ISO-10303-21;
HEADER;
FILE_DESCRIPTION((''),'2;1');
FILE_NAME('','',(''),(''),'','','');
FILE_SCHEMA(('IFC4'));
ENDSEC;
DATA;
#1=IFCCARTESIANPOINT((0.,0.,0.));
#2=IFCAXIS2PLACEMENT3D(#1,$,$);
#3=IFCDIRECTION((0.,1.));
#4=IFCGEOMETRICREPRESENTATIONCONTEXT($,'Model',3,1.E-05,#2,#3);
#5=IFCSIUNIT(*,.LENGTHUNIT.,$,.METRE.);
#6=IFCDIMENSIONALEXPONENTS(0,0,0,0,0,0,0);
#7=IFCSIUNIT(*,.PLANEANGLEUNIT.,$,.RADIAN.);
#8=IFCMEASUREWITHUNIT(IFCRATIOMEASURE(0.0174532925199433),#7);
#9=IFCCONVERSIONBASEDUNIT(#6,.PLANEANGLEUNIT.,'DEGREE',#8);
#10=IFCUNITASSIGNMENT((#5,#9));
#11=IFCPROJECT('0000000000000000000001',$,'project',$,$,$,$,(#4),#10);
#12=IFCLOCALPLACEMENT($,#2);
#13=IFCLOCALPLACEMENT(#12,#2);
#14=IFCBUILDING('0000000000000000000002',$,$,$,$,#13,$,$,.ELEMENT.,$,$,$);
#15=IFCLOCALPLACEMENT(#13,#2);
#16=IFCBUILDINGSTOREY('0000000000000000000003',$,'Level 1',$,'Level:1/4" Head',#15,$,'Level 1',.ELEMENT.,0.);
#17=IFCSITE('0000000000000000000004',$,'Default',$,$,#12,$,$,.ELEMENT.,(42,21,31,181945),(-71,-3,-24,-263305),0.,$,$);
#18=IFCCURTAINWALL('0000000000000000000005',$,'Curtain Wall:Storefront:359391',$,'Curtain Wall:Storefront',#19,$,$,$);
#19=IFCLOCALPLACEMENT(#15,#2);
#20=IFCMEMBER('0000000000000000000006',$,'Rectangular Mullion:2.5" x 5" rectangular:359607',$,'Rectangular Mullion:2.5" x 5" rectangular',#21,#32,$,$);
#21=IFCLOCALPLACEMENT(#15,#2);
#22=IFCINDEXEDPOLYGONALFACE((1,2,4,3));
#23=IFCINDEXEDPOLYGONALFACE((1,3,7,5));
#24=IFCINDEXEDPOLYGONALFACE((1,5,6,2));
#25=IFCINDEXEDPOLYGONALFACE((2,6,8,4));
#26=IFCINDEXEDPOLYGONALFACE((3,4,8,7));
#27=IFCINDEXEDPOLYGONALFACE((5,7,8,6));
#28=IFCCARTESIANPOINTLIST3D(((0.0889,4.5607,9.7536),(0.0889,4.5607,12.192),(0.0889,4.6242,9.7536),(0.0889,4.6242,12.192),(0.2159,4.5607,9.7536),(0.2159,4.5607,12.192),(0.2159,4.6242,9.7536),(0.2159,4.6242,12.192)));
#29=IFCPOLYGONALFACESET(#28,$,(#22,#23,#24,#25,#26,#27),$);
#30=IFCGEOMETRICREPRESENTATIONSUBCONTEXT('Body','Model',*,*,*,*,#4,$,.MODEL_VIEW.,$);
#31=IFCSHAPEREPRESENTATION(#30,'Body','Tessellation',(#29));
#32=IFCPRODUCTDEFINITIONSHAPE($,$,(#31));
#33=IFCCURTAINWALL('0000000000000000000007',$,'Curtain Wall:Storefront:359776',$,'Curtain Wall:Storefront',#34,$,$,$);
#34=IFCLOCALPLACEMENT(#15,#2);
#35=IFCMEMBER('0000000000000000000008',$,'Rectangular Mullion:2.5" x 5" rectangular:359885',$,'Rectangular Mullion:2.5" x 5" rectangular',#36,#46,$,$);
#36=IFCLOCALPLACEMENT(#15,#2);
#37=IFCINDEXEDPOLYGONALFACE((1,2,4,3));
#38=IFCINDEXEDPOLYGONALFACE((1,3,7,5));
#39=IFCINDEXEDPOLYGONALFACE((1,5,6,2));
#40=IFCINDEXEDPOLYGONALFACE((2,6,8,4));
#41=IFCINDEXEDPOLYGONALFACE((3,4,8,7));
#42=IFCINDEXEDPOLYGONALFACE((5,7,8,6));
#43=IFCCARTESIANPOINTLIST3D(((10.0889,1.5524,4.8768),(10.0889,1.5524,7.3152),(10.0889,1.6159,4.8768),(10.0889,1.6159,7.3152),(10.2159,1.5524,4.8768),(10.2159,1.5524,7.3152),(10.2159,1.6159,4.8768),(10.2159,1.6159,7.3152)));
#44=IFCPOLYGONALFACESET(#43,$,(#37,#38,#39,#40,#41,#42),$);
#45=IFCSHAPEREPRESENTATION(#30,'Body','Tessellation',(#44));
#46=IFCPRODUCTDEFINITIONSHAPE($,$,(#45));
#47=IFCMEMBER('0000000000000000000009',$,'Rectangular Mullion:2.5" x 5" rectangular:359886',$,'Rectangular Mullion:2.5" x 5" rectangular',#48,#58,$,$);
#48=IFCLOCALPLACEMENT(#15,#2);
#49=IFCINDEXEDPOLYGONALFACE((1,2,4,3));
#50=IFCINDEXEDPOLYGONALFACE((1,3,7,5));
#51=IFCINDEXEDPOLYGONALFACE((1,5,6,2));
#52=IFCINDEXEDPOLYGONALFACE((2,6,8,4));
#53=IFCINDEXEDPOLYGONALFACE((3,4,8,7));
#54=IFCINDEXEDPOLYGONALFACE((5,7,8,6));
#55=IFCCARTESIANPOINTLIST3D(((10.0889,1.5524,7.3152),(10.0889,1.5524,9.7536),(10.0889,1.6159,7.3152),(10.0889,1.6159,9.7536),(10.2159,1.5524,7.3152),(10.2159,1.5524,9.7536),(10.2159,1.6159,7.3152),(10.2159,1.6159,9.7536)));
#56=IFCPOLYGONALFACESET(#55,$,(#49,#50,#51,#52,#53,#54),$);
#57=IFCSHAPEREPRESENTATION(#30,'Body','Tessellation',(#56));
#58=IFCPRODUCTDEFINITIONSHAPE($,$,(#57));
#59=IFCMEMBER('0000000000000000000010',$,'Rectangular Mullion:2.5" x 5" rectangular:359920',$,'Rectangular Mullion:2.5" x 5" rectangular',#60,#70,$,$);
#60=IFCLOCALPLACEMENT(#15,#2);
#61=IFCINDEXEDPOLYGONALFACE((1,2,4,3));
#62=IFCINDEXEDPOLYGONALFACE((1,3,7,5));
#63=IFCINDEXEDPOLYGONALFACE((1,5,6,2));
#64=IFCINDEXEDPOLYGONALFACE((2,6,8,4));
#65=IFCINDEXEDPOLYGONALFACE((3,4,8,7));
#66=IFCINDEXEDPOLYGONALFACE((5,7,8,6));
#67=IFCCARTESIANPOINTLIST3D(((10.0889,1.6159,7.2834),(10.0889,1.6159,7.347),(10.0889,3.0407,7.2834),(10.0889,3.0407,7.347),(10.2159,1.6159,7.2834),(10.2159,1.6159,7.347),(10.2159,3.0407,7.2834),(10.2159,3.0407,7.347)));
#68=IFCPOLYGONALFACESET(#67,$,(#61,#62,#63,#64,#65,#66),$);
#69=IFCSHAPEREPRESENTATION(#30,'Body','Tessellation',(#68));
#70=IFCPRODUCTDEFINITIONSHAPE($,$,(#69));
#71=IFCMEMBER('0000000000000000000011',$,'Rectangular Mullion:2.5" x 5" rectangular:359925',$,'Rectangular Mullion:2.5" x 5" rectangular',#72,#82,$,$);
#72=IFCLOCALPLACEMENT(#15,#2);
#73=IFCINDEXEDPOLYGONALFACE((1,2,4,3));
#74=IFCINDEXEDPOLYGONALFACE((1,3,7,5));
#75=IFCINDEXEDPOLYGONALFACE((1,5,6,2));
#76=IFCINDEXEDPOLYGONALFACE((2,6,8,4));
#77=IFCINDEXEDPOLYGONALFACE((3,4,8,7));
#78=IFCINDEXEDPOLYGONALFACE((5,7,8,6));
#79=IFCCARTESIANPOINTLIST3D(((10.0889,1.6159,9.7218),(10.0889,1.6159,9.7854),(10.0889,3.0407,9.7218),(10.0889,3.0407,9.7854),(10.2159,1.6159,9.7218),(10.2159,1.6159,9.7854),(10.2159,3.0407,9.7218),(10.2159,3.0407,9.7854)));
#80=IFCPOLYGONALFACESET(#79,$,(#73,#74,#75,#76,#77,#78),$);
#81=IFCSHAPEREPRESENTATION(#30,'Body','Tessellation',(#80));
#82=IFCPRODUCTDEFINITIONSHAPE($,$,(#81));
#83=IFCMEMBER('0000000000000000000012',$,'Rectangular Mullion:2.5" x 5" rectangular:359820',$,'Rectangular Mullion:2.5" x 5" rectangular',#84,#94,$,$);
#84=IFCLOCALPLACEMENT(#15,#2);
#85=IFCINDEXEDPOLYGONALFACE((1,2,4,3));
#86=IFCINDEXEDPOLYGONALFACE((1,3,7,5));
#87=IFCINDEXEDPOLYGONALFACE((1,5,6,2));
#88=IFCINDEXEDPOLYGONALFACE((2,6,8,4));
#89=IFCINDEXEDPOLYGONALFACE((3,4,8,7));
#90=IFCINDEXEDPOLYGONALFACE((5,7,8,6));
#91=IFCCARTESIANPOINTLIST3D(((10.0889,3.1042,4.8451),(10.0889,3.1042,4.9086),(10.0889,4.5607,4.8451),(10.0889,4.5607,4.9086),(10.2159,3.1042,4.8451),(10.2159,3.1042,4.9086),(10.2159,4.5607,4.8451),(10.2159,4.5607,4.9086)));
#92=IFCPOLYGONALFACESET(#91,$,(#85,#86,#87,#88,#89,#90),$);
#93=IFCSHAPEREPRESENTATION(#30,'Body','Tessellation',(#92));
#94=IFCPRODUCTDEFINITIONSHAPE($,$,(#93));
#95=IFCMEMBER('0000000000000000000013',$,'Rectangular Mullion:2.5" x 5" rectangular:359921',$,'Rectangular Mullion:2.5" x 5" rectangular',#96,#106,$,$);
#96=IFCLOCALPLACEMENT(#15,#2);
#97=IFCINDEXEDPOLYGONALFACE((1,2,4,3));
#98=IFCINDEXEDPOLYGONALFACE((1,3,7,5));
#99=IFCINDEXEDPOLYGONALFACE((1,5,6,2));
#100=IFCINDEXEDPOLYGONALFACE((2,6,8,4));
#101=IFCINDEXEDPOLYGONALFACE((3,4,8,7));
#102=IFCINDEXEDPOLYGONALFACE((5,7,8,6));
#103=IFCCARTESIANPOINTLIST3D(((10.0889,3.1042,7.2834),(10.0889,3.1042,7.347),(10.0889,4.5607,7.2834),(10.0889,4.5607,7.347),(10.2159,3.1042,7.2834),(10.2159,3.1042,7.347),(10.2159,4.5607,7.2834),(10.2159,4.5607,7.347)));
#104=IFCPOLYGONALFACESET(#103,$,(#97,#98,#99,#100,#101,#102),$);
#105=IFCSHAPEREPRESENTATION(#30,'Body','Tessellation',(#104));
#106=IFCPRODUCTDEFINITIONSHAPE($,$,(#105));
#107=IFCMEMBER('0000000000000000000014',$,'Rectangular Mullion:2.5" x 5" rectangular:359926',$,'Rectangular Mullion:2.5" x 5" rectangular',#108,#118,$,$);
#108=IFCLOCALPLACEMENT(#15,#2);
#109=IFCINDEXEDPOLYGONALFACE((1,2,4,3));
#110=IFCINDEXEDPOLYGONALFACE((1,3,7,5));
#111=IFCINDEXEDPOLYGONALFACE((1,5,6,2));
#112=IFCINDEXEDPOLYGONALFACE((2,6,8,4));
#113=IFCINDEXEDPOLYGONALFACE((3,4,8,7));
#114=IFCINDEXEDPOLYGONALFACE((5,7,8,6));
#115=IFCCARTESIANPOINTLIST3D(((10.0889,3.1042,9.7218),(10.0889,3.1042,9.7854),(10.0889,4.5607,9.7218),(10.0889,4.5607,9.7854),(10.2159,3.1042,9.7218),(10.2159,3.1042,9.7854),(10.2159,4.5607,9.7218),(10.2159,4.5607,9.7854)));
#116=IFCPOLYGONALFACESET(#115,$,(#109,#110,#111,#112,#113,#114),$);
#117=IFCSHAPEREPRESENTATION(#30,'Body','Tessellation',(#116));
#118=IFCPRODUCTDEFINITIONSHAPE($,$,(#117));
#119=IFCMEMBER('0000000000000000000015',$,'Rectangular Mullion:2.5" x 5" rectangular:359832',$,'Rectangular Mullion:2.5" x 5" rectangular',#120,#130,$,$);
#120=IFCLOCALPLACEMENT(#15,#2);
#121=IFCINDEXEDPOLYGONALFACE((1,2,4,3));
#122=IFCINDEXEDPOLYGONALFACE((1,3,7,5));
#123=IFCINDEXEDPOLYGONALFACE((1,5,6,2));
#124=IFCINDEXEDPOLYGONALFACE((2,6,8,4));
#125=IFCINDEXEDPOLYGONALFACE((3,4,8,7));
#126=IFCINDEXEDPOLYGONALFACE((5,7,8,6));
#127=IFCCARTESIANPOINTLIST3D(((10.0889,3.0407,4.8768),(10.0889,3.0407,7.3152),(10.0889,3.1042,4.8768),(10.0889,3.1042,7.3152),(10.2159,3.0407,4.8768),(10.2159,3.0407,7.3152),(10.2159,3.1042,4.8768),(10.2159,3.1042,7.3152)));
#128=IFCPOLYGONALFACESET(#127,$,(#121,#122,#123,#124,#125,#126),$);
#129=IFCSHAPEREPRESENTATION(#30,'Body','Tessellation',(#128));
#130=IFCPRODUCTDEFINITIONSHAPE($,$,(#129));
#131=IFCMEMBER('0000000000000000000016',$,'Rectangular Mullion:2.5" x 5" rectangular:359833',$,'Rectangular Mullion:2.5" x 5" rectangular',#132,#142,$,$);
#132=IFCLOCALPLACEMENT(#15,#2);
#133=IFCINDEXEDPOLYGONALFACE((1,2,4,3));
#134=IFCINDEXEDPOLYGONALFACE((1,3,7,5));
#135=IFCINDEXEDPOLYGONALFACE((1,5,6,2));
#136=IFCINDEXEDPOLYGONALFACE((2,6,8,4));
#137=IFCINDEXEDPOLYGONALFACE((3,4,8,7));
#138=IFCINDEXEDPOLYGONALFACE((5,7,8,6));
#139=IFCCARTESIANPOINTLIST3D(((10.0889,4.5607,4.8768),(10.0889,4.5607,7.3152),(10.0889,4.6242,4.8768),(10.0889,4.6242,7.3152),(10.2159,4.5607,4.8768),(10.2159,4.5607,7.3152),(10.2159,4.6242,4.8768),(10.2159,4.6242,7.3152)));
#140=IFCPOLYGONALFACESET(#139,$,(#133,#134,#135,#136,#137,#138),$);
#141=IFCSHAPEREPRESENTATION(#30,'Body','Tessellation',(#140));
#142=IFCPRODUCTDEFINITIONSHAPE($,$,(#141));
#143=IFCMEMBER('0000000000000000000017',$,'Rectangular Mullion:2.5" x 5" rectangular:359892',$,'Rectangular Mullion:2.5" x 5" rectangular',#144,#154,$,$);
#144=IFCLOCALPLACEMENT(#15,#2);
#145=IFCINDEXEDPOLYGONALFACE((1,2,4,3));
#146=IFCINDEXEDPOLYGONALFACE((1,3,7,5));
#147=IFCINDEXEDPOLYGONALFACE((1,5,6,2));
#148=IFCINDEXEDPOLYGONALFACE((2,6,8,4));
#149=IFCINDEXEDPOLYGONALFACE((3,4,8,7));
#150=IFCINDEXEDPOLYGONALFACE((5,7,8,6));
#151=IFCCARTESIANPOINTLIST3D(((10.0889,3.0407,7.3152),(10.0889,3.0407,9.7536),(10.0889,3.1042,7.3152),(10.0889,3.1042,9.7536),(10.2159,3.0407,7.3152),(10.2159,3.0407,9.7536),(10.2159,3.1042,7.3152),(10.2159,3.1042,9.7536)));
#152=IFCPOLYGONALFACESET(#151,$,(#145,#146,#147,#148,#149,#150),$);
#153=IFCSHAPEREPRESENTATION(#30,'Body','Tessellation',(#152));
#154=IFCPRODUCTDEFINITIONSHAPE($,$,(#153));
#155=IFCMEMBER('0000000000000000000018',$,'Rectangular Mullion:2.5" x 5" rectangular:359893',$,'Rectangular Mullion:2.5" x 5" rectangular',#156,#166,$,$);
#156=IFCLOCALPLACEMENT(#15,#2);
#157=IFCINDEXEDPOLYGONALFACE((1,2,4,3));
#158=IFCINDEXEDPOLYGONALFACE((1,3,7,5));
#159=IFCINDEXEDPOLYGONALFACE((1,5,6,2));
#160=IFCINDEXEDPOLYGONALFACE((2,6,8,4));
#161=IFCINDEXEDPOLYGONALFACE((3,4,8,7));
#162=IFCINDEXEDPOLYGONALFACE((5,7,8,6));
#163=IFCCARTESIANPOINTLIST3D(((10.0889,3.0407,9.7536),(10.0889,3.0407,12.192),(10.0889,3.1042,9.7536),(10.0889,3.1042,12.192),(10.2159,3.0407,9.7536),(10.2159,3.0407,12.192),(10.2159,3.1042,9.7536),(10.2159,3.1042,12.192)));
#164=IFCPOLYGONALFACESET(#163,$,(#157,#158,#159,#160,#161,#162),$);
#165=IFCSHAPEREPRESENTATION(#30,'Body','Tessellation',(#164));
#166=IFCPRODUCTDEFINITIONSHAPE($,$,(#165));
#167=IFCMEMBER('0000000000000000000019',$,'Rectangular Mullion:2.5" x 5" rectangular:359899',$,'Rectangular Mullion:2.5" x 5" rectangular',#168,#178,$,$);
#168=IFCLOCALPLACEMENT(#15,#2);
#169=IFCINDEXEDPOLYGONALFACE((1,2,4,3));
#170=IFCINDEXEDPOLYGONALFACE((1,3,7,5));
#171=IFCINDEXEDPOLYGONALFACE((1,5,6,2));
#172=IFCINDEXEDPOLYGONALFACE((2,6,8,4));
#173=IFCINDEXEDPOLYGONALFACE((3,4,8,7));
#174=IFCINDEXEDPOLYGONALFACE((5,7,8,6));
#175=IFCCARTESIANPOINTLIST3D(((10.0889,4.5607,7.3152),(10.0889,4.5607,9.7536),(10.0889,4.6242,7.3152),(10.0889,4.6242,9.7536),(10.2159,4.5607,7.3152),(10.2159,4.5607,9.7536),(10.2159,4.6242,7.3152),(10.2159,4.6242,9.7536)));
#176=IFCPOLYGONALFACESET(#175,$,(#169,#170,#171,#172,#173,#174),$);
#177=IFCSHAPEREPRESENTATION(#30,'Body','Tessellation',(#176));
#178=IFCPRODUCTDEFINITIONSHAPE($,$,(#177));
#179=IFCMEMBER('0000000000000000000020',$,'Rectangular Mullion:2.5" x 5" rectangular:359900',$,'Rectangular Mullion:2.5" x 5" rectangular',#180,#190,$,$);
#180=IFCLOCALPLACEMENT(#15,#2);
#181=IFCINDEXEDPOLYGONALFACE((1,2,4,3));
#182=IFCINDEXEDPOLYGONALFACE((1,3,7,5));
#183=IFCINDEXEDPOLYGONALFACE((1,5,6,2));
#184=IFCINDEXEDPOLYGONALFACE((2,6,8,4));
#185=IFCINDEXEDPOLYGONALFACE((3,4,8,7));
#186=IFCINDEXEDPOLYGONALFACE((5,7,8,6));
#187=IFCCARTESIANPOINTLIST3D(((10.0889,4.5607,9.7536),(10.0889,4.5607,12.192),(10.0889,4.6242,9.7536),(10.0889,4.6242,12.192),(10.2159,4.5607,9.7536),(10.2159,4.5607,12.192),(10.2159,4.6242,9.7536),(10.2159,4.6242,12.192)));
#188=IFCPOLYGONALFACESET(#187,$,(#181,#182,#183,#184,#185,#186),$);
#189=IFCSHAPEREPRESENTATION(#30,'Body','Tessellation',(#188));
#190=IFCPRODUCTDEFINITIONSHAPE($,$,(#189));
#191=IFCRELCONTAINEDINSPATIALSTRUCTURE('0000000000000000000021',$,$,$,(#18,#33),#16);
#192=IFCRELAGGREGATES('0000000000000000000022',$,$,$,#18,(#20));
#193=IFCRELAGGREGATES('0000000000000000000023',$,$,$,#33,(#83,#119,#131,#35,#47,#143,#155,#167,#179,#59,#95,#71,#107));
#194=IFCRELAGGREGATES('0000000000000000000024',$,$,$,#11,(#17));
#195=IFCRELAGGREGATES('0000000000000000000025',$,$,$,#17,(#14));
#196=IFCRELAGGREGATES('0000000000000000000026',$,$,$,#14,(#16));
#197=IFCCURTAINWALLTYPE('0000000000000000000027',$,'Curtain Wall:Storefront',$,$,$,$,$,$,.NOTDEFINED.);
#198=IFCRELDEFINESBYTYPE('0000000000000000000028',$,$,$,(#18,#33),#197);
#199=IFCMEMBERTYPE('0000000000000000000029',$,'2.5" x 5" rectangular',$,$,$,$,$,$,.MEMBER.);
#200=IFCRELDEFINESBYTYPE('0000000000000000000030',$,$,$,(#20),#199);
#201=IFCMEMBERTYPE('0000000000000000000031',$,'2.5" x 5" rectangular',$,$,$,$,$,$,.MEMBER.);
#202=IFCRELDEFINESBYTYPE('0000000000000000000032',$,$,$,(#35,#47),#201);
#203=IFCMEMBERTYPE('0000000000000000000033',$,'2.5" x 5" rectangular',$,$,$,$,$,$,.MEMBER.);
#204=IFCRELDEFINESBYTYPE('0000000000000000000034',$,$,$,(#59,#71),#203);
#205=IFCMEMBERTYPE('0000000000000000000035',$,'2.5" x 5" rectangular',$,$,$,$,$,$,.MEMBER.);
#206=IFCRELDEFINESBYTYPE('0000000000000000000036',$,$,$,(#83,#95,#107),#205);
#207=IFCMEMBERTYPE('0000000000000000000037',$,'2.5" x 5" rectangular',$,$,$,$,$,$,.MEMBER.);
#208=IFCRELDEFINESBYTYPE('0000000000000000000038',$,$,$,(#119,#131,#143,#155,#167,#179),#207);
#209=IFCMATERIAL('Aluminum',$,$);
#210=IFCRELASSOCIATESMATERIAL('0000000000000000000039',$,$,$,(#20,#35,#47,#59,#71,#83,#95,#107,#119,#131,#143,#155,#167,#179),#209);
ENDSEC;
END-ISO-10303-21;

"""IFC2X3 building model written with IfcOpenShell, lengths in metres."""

from ifc_helpers import new_model, entity, si_unit, converted_unit, direction, frame, origin, origin_2d_with_axis, place, context, subcontext, project, spatial, rectangle, extrude, source, transform, mapped, material, type_object, type_shapes, element, aggregate, save


model = new_model("IFC2X3")

# Units and contexts
model_context = context("Model", 3, precision=1e-05, world=origin(), true_north=direction((0.0, 1.0)))
body_context = subcontext(model_context, "Body", "Model", "MODEL_VIEW")
ifc_project = project(units=[si_unit("LENGTHUNIT", "METRE"), converted_unit("PLANEANGLEUNIT", "DEGREE", entity("IfcRatioMeasure", 0.0174532925199433), si_unit("PLANEANGLEUNIT", "RADIAN"), dimensions=[0, 0, 0, 0, 0, 0, 0])], contexts=[model_context])

# Site, building, storey
site_placement = place(None, origin())
site = spatial("IfcSite", under=ifc_project, at=site_placement, Name="Default", CompositionType="ELEMENT", RefLatitude=(42, 21, 31, 181945), RefLongitude=(-71, -3, -24, -263305), RefElevation=0.0)
building_placement = place(site_placement, origin())
building = spatial("IfcBuilding", under=site, at=building_placement, CompositionType="ELEMENT")
storey_placement = place(building_placement, origin())
storey = spatial("IfcBuildingStorey", under=building, at=storey_placement, Name="Level 1", ObjectType="Level:1/4\" Head", LongName="Level 1", CompositionType="ELEMENT", Elevation=0.0)

# Curtain wall, member
curtain_wall_type = type_object("IfcCurtainWallType", Name="Curtain Wall:Storefront", PredefinedType="NOTDEFINED")
curtain_wall_1_placement = place(storey_placement, origin())
curtain_wall_1 = element("IfcCurtainWall", 1, at=curtain_wall_1_placement, inside=storey, type_object=curtain_wall_type, Name="Curtain Wall:Storefront:359391", ObjectType="Curtain Wall:Storefront")
ifc_material_1 = material(Name="Aluminum")
member_type_1 = type_object("IfcMemberType", Name="2.5\" x 5\" rectangular", PredefinedType="MEMBER")
shared_shape_1 = source(origin(), body_context, "Body", "SweptSolid", [
    extrude(rectangle(XDim=0.127, YDim=0.0635, at=origin_2d_with_axis()), frame((0.0, 0.0, -2.4384), z_axis=(0.0, 0.0, 1.0), x_axis=(0.0, -1.0, 0.0)), (0.0, 0.0, 1.0), 2.4384),
])
type_shapes(member_type_1, [shared_shape_1])
member_1_placement = place(storey_placement, frame((0.1524, 4.5924, 9.7536), z_axis=(0.0, 0.0, -1.0), x_axis=(0.0, 1.0, 0.0)))
member_1 = element("IfcMember", 2, at=member_1_placement, type_object=member_type_1, material=ifc_material_1, Name="Rectangular Mullion:2.5\" x 5\" rectangular:359607", ObjectType="Rectangular Mullion:2.5\" x 5\" rectangular", context=body_context, shape_type="MappedRepresentation", body=[
    mapped(shared_shape_1, transform((0.0, 0.0, 0.0), scale=1.0)),
])
aggregate(curtain_wall_1, [member_1])

# Curtain wall, members
curtain_wall_2_placement = place(storey_placement, origin())
curtain_wall_2 = element("IfcCurtainWall", 3, at=curtain_wall_2_placement, inside=storey, type_object=curtain_wall_type, Name="Curtain Wall:Storefront:359776", ObjectType="Curtain Wall:Storefront")
member_type_2 = type_object("IfcMemberType", Name="2.5\" x 5\" rectangular", PredefinedType="MEMBER")
shared_shape_2 = source(origin(), body_context, "Body", "SweptSolid", [
    extrude(rectangle(XDim=0.127, YDim=0.0635, at=origin_2d_with_axis()), frame((-0.0318, 0.0, -2.4384), z_axis=(0.0, 0.0, 1.0), x_axis=(0.0, -1.0, 0.0)), (0.0, 0.0, 1.0), 2.4384),
])
type_shapes(member_type_2, [shared_shape_2])
member_2_placement = place(storey_placement, frame((10.1524, 1.5524, 7.3152), z_axis=(0.0, 0.0, 1.0), x_axis=(0.0, -1.0, 0.0)))
member_2 = element("IfcMember", 4, at=member_2_placement, type_object=member_type_2, material=ifc_material_1, Name="Rectangular Mullion:2.5\" x 5\" rectangular:359885", ObjectType="Rectangular Mullion:2.5\" x 5\" rectangular", context=body_context, shape_type="MappedRepresentation", body=[
    mapped(shared_shape_2, transform((0.0, 0.0, 0.0), scale=1.0)),
])
member_3_placement = place(storey_placement, frame((10.1524, 1.5524, 9.7536), z_axis=(0.0, 0.0, 1.0), x_axis=(0.0, -1.0, 0.0)))
member_3 = element("IfcMember", 5, at=member_3_placement, type_object=member_type_2, material=ifc_material_1, Name="Rectangular Mullion:2.5\" x 5\" rectangular:359886", ObjectType="Rectangular Mullion:2.5\" x 5\" rectangular", context=body_context, shape_type="MappedRepresentation", body=[
    mapped(shared_shape_2, transform((0.0, 0.0, 0.0), scale=1.0)),
])
member_type_3 = type_object("IfcMemberType", Name="2.5\" x 5\" rectangular", PredefinedType="MEMBER")
shared_shape_3 = source(origin(), body_context, "Body", "SweptSolid", [
    extrude(rectangle(XDim=0.127, YDim=0.0635, at=origin_2d_with_axis()), frame((0.0, 0.0, -1.4248), z_axis=(0.0, 0.0, 1.0), x_axis=(0.0, -1.0, 0.0)), (0.0, 0.0, 1.0), 1.4248),
])
type_shapes(member_type_3, [shared_shape_3])
member_4_placement = place(storey_placement, frame((10.1524, 3.0407, 7.3152), z_axis=(0.0, 1.0, 0.0), x_axis=(0.0, 0.0, 1.0)))
member_4 = element("IfcMember", 6, at=member_4_placement, type_object=member_type_3, material=ifc_material_1, Name="Rectangular Mullion:2.5\" x 5\" rectangular:359920", ObjectType="Rectangular Mullion:2.5\" x 5\" rectangular", context=body_context, shape_type="MappedRepresentation", body=[
    mapped(shared_shape_3, transform((0.0, 0.0, 0.0), scale=1.0)),
])
member_5_placement = place(storey_placement, frame((10.1524, 3.0407, 9.7536), z_axis=(0.0, 1.0, 0.0), x_axis=(0.0, 0.0, 1.0)))
member_5 = element("IfcMember", 7, at=member_5_placement, type_object=member_type_3, material=ifc_material_1, Name="Rectangular Mullion:2.5\" x 5\" rectangular:359925", ObjectType="Rectangular Mullion:2.5\" x 5\" rectangular", context=body_context, shape_type="MappedRepresentation", body=[
    mapped(shared_shape_3, transform((0.0, 0.0, 0.0), scale=1.0)),
])
member_type_4 = type_object("IfcMemberType", Name="2.5\" x 5\" rectangular", PredefinedType="MEMBER")
shared_shape_4 = source(origin(), body_context, "Body", "SweptSolid", [
    extrude(rectangle(XDim=0.127, YDim=0.0635, at=origin_2d_with_axis()), frame((0.0, 0.0, -1.4565), z_axis=(0.0, 0.0, 1.0), x_axis=(0.0, -1.0, 0.0)), (0.0, 0.0, 1.0), 1.4565),
])
type_shapes(member_type_4, [shared_shape_4])
member_6_placement = place(storey_placement, frame((10.1524, 4.5607, 4.8768), z_axis=(0.0, 1.0, 0.0), x_axis=(0.0, 0.0, 1.0)))
member_6 = element("IfcMember", 8, at=member_6_placement, type_object=member_type_4, material=ifc_material_1, Name="Rectangular Mullion:2.5\" x 5\" rectangular:359820", ObjectType="Rectangular Mullion:2.5\" x 5\" rectangular", context=body_context, shape_type="MappedRepresentation", body=[
    mapped(shared_shape_4, transform((0.0, 0.0, 0.0), scale=1.0)),
])
member_7_placement = place(storey_placement, frame((10.1524, 4.5607, 7.3152), z_axis=(0.0, 1.0, 0.0), x_axis=(0.0, 0.0, 1.0)))
member_7 = element("IfcMember", 9, at=member_7_placement, type_object=member_type_4, material=ifc_material_1, Name="Rectangular Mullion:2.5\" x 5\" rectangular:359921", ObjectType="Rectangular Mullion:2.5\" x 5\" rectangular", context=body_context, shape_type="MappedRepresentation", body=[
    mapped(shared_shape_4, transform((0.0, 0.0, 0.0), scale=1.0)),
])
member_8_placement = place(storey_placement, frame((10.1524, 4.5607, 9.7536), z_axis=(0.0, 1.0, 0.0), x_axis=(0.0, 0.0, 1.0)))
member_8 = element("IfcMember", 10, at=member_8_placement, type_object=member_type_4, material=ifc_material_1, Name="Rectangular Mullion:2.5\" x 5\" rectangular:359926", ObjectType="Rectangular Mullion:2.5\" x 5\" rectangular", context=body_context, shape_type="MappedRepresentation", body=[
    mapped(shared_shape_4, transform((0.0, 0.0, 0.0), scale=1.0)),
])
member_type_5 = type_object("IfcMemberType", Name="2.5\" x 5\" rectangular", PredefinedType="MEMBER")
shared_shape_5 = source(origin(), body_context, "Body", "SweptSolid", [
    extrude(rectangle(XDim=0.127, YDim=0.0635, at=origin_2d_with_axis()), frame((0.0, 0.0, -2.4384), z_axis=(0.0, 0.0, 1.0), x_axis=(0.0, -1.0, 0.0)), (0.0, 0.0, 1.0), 2.4384),
])
type_shapes(member_type_5, [shared_shape_5])
member_9_placement = place(storey_placement, frame((10.1524, 3.0724, 4.8768), z_axis=(0.0, 0.0, -1.0), x_axis=(0.0, 1.0, 0.0)))
member_9 = element("IfcMember", 11, at=member_9_placement, type_object=member_type_5, material=ifc_material_1, Name="Rectangular Mullion:2.5\" x 5\" rectangular:359832", ObjectType="Rectangular Mullion:2.5\" x 5\" rectangular", context=body_context, shape_type="MappedRepresentation", body=[
    mapped(shared_shape_5, transform((0.0, 0.0, 0.0), scale=1.0)),
])
member_10_placement = place(storey_placement, frame((10.1524, 4.5924, 4.8768), z_axis=(0.0, 0.0, -1.0), x_axis=(0.0, 1.0, 0.0)))
member_10 = element("IfcMember", 12, at=member_10_placement, type_object=member_type_5, material=ifc_material_1, Name="Rectangular Mullion:2.5\" x 5\" rectangular:359833", ObjectType="Rectangular Mullion:2.5\" x 5\" rectangular", context=body_context, shape_type="MappedRepresentation", body=[
    mapped(shared_shape_5, transform((0.0, 0.0, 0.0), scale=1.0)),
])
member_11_placement = place(storey_placement, frame((10.1524, 3.0724, 7.3152), z_axis=(0.0, 0.0, -1.0), x_axis=(0.0, 1.0, 0.0)))
member_11 = element("IfcMember", 13, at=member_11_placement, type_object=member_type_5, material=ifc_material_1, Name="Rectangular Mullion:2.5\" x 5\" rectangular:359892", ObjectType="Rectangular Mullion:2.5\" x 5\" rectangular", context=body_context, shape_type="MappedRepresentation", body=[
    mapped(shared_shape_5, transform((0.0, 0.0, 0.0), scale=1.0)),
])
member_12_placement = place(storey_placement, frame((10.1524, 3.0724, 9.7536), z_axis=(0.0, 0.0, -1.0), x_axis=(0.0, 1.0, 0.0)))
member_12 = element("IfcMember", 14, at=member_12_placement, type_object=member_type_5, material=ifc_material_1, Name="Rectangular Mullion:2.5\" x 5\" rectangular:359893", ObjectType="Rectangular Mullion:2.5\" x 5\" rectangular", context=body_context, shape_type="MappedRepresentation", body=[
    mapped(shared_shape_5, transform((0.0, 0.0, 0.0), scale=1.0)),
])
member_13_placement = place(storey_placement, frame((10.1524, 4.5924, 7.3152), z_axis=(0.0, 0.0, -1.0), x_axis=(0.0, 1.0, 0.0)))
member_13 = element("IfcMember", 15, at=member_13_placement, type_object=member_type_5, material=ifc_material_1, Name="Rectangular Mullion:2.5\" x 5\" rectangular:359899", ObjectType="Rectangular Mullion:2.5\" x 5\" rectangular", context=body_context, shape_type="MappedRepresentation", body=[
    mapped(shared_shape_5, transform((0.0, 0.0, 0.0), scale=1.0)),
])
member_14_placement = place(storey_placement, frame((10.1524, 4.5924, 9.7536), z_axis=(0.0, 0.0, -1.0), x_axis=(0.0, 1.0, 0.0)))
member_14 = element("IfcMember", 16, at=member_14_placement, type_object=member_type_5, material=ifc_material_1, Name="Rectangular Mullion:2.5\" x 5\" rectangular:359900", ObjectType="Rectangular Mullion:2.5\" x 5\" rectangular", context=body_context, shape_type="MappedRepresentation", body=[
    mapped(shared_shape_5, transform((0.0, 0.0, 0.0), scale=1.0)),
])
aggregate(curtain_wall_2, [member_6, member_9, member_10, member_2, member_3, member_11, member_12, member_13, member_14, member_4, member_7, member_5, member_8])

save(model, "model.ifc")
